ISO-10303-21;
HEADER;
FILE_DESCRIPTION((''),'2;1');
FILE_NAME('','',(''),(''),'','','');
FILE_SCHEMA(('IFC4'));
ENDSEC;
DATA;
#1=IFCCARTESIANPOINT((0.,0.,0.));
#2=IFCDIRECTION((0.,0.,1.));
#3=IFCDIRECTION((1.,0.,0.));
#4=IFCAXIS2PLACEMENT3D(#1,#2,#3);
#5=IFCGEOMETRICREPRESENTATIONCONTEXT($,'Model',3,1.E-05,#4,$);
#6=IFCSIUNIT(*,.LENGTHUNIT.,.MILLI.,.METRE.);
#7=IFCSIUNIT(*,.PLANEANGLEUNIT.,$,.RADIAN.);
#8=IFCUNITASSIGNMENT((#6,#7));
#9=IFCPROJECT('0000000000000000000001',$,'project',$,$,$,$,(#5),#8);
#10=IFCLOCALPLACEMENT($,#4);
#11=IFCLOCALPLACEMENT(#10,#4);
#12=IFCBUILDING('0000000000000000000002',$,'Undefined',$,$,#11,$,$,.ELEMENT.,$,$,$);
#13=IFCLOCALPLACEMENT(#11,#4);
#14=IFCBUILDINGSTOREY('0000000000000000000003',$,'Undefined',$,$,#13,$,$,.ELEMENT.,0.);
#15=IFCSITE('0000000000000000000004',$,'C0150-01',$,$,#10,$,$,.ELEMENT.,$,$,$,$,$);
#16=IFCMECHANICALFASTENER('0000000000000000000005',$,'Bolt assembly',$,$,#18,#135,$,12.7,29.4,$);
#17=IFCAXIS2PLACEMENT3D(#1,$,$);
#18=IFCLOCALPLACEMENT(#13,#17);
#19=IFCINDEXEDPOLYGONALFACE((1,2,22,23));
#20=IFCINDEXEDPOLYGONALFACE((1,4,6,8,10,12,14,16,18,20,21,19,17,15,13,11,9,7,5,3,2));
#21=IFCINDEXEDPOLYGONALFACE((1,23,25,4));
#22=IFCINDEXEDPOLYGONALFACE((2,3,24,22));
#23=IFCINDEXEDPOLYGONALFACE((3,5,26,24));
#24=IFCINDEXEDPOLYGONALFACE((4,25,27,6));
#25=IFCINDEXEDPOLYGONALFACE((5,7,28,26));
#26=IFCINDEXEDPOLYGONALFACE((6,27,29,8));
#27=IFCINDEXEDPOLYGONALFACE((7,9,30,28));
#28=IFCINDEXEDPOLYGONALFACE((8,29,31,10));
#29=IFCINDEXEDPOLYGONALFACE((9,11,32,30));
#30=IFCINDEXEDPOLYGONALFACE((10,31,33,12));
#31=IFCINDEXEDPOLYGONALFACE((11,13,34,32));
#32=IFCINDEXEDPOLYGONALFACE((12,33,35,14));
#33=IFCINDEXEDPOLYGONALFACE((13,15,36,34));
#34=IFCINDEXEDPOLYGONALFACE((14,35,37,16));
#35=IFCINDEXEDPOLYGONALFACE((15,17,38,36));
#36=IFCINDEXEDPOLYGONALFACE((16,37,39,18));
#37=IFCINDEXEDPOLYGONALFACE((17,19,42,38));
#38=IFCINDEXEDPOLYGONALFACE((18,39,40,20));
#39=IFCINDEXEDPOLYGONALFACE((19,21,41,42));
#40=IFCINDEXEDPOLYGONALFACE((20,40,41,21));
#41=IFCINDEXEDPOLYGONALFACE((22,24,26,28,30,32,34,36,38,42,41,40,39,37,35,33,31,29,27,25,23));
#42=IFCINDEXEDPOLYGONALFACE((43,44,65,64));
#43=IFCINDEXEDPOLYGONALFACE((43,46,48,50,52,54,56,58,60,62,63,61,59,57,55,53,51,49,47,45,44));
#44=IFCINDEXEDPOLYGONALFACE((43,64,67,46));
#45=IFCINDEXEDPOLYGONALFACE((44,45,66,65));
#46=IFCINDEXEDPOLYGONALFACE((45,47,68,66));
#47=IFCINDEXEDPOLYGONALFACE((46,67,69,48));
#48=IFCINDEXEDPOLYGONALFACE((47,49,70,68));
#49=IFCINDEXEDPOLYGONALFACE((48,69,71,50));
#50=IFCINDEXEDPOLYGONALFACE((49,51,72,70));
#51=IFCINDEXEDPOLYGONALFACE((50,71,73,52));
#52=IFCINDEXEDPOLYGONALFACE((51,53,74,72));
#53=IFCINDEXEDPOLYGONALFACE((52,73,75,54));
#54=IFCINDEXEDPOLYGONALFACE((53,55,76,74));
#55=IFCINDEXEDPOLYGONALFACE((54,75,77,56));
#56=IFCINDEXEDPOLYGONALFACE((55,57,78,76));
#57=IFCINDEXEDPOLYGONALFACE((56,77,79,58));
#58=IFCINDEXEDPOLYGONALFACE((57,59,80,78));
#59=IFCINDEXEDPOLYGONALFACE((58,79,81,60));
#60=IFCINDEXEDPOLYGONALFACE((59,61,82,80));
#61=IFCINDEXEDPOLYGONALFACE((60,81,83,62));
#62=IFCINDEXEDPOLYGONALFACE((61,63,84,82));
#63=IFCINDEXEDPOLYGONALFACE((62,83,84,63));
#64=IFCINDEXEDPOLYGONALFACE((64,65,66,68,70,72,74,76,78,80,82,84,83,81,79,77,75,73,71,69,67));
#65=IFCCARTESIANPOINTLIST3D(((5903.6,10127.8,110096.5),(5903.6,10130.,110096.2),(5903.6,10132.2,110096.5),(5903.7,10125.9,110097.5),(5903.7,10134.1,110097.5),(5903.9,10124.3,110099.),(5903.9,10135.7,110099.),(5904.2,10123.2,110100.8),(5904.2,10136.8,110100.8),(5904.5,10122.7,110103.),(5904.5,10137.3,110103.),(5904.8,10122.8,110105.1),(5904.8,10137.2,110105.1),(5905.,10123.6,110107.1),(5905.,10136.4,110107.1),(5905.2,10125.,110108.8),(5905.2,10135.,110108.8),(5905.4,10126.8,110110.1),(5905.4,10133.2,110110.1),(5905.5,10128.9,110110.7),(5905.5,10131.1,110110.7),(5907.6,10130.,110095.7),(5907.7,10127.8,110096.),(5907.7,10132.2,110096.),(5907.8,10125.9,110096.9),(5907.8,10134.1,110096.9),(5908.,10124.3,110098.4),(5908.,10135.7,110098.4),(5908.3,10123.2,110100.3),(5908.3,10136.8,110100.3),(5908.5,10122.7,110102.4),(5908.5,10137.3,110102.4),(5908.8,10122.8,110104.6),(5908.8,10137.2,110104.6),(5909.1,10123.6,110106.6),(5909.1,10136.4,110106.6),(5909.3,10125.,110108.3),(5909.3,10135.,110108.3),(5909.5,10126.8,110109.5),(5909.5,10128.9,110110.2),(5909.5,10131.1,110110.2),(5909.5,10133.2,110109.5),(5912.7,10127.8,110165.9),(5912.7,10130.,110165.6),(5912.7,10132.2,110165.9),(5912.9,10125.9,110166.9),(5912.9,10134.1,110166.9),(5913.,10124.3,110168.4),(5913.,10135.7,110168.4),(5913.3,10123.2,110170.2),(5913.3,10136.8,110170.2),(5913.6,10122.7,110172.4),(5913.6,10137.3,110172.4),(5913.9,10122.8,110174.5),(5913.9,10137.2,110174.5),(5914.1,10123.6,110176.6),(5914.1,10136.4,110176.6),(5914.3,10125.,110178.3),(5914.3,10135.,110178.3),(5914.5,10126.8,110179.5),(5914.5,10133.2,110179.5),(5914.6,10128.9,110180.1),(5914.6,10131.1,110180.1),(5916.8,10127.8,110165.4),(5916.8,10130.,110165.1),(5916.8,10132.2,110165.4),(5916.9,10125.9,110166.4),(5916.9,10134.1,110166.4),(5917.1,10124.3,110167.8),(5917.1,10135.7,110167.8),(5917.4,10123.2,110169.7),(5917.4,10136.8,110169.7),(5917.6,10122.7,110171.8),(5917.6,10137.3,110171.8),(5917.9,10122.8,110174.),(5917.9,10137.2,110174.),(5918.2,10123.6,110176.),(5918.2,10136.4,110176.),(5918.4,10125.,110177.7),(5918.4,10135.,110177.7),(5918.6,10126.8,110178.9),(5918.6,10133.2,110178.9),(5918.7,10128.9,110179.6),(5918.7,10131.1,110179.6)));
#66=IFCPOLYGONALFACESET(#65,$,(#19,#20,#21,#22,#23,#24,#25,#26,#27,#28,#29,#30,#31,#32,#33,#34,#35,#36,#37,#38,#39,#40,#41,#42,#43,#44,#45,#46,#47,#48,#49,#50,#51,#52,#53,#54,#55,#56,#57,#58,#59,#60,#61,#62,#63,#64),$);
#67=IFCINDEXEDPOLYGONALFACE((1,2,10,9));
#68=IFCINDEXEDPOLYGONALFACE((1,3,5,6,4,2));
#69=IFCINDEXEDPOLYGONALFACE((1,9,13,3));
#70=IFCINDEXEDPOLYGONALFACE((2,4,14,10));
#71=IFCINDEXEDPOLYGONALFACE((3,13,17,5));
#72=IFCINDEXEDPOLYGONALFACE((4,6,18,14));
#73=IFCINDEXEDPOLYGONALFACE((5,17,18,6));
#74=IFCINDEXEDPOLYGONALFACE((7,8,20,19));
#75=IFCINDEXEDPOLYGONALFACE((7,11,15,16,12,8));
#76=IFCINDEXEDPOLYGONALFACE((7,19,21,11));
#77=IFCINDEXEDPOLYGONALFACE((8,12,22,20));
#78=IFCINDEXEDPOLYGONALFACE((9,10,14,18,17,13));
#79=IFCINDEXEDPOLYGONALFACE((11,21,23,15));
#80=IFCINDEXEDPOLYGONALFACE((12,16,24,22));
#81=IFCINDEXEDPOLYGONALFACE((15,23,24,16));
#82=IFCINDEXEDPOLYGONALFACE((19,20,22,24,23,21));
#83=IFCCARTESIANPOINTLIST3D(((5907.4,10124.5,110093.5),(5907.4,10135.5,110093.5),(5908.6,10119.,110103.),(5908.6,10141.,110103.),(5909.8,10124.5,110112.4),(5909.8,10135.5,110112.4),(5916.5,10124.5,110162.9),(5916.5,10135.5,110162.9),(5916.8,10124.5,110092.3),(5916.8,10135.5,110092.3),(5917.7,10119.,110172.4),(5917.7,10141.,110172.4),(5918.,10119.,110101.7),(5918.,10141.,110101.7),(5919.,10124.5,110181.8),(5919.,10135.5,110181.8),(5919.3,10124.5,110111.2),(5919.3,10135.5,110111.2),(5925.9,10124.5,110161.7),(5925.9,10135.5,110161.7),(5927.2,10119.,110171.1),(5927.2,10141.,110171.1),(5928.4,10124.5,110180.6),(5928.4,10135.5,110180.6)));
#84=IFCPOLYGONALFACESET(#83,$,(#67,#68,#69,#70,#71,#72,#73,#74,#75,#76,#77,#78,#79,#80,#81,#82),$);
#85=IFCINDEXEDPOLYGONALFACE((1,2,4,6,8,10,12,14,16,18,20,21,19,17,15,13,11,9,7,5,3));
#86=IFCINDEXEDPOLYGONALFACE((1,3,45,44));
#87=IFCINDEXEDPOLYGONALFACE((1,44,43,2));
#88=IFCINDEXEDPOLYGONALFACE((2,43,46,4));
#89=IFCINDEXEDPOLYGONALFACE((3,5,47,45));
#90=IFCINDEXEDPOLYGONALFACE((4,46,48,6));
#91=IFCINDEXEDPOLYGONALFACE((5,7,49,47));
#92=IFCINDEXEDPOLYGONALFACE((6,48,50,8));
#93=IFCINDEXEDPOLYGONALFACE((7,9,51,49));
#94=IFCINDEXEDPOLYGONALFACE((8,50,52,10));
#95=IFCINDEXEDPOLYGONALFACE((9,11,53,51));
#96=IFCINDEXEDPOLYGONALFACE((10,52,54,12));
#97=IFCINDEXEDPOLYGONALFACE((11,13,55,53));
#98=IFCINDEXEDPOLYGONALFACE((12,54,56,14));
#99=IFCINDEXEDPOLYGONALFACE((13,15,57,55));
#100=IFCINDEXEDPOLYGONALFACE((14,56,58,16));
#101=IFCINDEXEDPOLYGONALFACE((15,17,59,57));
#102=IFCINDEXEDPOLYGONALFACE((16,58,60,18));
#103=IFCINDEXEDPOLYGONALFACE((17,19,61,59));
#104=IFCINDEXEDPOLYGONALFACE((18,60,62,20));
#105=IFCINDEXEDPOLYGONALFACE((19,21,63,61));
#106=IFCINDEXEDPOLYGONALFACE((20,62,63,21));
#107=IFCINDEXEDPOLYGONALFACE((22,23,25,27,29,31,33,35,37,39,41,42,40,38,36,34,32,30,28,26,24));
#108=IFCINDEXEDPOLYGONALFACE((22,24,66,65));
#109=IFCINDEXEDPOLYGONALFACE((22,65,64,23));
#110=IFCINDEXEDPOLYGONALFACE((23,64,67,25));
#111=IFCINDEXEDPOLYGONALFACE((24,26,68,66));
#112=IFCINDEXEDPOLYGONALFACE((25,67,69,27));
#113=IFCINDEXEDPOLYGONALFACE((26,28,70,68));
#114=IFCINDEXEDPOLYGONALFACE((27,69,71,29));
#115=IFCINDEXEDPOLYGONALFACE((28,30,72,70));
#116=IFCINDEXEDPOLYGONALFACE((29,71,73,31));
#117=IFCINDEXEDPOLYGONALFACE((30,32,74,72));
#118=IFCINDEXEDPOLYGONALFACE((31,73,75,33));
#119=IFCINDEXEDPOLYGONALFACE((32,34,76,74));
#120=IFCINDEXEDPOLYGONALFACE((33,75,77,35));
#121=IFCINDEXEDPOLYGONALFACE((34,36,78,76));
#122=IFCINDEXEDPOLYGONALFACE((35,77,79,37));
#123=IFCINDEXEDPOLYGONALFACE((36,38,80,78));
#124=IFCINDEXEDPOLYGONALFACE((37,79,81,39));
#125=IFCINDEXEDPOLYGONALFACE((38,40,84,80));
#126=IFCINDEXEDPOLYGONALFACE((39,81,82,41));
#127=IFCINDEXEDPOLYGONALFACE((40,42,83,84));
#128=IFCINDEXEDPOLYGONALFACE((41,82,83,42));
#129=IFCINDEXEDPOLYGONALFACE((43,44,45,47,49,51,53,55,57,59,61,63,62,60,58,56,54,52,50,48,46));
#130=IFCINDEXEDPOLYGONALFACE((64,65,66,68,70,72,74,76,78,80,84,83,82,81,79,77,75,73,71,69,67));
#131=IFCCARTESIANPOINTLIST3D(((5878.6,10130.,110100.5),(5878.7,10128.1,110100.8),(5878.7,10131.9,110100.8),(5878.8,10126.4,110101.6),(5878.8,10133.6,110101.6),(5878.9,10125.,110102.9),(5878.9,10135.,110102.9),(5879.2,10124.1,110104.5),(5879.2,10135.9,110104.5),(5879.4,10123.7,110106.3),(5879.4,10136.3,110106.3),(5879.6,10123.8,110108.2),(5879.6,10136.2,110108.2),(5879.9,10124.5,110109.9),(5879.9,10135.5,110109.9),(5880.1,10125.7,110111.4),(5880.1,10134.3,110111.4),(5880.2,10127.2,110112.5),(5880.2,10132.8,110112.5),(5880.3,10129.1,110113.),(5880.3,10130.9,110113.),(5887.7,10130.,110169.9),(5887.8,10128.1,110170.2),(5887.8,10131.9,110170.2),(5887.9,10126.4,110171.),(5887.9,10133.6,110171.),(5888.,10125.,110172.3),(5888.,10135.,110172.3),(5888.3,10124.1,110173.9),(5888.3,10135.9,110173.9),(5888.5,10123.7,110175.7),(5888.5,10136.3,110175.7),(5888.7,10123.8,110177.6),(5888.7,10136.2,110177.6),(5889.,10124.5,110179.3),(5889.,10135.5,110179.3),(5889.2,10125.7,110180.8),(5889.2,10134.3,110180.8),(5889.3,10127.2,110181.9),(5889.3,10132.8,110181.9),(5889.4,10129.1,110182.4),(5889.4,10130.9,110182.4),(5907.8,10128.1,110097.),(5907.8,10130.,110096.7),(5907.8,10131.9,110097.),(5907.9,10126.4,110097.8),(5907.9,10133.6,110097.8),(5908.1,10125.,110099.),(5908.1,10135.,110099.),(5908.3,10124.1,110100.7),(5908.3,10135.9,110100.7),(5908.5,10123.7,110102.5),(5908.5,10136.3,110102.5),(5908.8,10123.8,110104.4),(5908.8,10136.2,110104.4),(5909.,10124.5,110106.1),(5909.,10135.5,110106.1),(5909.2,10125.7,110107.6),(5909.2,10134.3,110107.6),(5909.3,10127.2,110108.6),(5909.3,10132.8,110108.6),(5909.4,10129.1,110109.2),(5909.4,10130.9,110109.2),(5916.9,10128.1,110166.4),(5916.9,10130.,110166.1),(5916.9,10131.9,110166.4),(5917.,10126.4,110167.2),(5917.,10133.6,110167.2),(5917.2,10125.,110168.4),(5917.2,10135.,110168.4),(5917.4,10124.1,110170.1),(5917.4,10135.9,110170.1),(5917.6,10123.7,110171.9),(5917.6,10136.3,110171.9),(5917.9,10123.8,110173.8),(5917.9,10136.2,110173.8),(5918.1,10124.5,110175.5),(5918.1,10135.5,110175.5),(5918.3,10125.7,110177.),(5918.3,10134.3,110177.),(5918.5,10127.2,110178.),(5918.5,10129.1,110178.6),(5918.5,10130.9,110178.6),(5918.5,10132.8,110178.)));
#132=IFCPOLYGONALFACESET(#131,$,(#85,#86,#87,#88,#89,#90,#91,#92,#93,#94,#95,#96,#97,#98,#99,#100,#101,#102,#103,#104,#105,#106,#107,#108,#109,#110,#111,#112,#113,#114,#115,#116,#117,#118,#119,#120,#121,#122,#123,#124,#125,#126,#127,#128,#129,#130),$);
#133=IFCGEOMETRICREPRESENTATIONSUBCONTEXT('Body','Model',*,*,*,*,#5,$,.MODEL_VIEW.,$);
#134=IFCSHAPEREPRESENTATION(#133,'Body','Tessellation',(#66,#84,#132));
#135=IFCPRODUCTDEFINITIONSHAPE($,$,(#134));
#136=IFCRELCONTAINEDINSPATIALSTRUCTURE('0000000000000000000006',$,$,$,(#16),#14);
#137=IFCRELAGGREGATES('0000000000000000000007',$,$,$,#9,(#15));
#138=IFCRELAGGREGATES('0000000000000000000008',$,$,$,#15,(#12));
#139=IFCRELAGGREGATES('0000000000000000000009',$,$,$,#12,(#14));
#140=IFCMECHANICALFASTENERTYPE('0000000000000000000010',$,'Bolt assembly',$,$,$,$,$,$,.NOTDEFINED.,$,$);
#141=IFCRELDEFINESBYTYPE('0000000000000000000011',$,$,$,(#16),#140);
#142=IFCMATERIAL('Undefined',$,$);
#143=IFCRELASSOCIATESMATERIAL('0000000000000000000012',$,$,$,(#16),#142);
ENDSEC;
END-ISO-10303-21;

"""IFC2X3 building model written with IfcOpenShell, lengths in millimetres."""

from ifc_helpers import new_model, si_unit, frame, origin_with_axes, origin_2d_with_axis, place, context, subcontext, project, spatial, polyline, circle, outline, extrude, source, transform, mapped, material, type_object, element, save


model = new_model("IFC2X3")

# Units and contexts
model_context = context("Model", 3, precision=1e-05, world=origin_with_axes())
body_context = subcontext(model_context, "Body", "Model", "MODEL_VIEW")
ifc_project = project(units=[si_unit("LENGTHUNIT", "METRE", prefix="MILLI"), si_unit("PLANEANGLEUNIT", "RADIAN")], contexts=[model_context])

# Site, building, storey
site_placement = place(None, origin_with_axes())
site = spatial("IfcSite", under=ifc_project, at=site_placement, Name="C0150-01", CompositionType="ELEMENT")
building_placement = place(site_placement, origin_with_axes())
building = spatial("IfcBuilding", under=site, at=building_placement, Name="Undefined", CompositionType="ELEMENT")
storey_placement = place(building_placement, origin_with_axes())
storey = spatial("IfcBuildingStorey", under=building, at=storey_placement, Name="Undefined", CompositionType="ELEMENT", Elevation=0.0)

# Mechanical fastener
ifc_material_1 = material(Name="Undefined")
mechanical_fastener_type = type_object("IfcMechanicalFastenerType", Name="Bolt assembly")
shared_shape_1 = source(origin_with_axes(), body_context, "Body", "SweptSolid", [
    extrude(circle(Radius=7.3, at=origin_2d_with_axis()), frame((0.0, 0.0, 0.0), z_axis=(0.0, 1.0, 0.0), x_axis=(1.0, 0.0, 0.0)), (0.0, 0.0, 1.0), 4.1),
    extrude(outline(polyline([(9.5, -5.5), (9.5, 5.5), (0.0, 11.0), (-9.5, 5.5), (-9.5, -5.5), (0.0, -11.0), (9.5, -5.5)])), frame((0.0, -9.5, 0.0), z_axis=(0.0, 1.0, 0.0), x_axis=(1.0, 0.0, 0.0)), (0.0, 0.0, 1.0), 9.5),
    extrude(circle(Radius=6.3, at=origin_2d_with_axis()), frame((0.0, 0.0, 0.0), z_axis=(0.0, 1.0, 0.0), x_axis=(1.0, 0.0, 0.0)), (0.0, 0.0, 1.0), 29.4),
])
for number, where, z_axis, x_axis, name in (
    (1, (5917.7, 10130.0, 110172.4), (0.0, 1.0, 0.0), (-0.130054, 0.0, -0.991507), "Bolt assembly"),
):
    element("IfcMechanicalFastener", number, at=place(storey_placement, frame(where, z_axis=z_axis, x_axis=x_axis)), inside=storey, type_object=mechanical_fastener_type, material=ifc_material_1, Name=name, NominalDiameter=12.7, NominalLength=29.4, context=body_context, shape_type="MappedRepresentation", body=[
        mapped(shared_shape_1, transform((0.0, 0.0, 0.0))),
        mapped(shared_shape_1, transform((70.0, 0.0, 0.0))),
    ])

save(model, "model.ifc")
